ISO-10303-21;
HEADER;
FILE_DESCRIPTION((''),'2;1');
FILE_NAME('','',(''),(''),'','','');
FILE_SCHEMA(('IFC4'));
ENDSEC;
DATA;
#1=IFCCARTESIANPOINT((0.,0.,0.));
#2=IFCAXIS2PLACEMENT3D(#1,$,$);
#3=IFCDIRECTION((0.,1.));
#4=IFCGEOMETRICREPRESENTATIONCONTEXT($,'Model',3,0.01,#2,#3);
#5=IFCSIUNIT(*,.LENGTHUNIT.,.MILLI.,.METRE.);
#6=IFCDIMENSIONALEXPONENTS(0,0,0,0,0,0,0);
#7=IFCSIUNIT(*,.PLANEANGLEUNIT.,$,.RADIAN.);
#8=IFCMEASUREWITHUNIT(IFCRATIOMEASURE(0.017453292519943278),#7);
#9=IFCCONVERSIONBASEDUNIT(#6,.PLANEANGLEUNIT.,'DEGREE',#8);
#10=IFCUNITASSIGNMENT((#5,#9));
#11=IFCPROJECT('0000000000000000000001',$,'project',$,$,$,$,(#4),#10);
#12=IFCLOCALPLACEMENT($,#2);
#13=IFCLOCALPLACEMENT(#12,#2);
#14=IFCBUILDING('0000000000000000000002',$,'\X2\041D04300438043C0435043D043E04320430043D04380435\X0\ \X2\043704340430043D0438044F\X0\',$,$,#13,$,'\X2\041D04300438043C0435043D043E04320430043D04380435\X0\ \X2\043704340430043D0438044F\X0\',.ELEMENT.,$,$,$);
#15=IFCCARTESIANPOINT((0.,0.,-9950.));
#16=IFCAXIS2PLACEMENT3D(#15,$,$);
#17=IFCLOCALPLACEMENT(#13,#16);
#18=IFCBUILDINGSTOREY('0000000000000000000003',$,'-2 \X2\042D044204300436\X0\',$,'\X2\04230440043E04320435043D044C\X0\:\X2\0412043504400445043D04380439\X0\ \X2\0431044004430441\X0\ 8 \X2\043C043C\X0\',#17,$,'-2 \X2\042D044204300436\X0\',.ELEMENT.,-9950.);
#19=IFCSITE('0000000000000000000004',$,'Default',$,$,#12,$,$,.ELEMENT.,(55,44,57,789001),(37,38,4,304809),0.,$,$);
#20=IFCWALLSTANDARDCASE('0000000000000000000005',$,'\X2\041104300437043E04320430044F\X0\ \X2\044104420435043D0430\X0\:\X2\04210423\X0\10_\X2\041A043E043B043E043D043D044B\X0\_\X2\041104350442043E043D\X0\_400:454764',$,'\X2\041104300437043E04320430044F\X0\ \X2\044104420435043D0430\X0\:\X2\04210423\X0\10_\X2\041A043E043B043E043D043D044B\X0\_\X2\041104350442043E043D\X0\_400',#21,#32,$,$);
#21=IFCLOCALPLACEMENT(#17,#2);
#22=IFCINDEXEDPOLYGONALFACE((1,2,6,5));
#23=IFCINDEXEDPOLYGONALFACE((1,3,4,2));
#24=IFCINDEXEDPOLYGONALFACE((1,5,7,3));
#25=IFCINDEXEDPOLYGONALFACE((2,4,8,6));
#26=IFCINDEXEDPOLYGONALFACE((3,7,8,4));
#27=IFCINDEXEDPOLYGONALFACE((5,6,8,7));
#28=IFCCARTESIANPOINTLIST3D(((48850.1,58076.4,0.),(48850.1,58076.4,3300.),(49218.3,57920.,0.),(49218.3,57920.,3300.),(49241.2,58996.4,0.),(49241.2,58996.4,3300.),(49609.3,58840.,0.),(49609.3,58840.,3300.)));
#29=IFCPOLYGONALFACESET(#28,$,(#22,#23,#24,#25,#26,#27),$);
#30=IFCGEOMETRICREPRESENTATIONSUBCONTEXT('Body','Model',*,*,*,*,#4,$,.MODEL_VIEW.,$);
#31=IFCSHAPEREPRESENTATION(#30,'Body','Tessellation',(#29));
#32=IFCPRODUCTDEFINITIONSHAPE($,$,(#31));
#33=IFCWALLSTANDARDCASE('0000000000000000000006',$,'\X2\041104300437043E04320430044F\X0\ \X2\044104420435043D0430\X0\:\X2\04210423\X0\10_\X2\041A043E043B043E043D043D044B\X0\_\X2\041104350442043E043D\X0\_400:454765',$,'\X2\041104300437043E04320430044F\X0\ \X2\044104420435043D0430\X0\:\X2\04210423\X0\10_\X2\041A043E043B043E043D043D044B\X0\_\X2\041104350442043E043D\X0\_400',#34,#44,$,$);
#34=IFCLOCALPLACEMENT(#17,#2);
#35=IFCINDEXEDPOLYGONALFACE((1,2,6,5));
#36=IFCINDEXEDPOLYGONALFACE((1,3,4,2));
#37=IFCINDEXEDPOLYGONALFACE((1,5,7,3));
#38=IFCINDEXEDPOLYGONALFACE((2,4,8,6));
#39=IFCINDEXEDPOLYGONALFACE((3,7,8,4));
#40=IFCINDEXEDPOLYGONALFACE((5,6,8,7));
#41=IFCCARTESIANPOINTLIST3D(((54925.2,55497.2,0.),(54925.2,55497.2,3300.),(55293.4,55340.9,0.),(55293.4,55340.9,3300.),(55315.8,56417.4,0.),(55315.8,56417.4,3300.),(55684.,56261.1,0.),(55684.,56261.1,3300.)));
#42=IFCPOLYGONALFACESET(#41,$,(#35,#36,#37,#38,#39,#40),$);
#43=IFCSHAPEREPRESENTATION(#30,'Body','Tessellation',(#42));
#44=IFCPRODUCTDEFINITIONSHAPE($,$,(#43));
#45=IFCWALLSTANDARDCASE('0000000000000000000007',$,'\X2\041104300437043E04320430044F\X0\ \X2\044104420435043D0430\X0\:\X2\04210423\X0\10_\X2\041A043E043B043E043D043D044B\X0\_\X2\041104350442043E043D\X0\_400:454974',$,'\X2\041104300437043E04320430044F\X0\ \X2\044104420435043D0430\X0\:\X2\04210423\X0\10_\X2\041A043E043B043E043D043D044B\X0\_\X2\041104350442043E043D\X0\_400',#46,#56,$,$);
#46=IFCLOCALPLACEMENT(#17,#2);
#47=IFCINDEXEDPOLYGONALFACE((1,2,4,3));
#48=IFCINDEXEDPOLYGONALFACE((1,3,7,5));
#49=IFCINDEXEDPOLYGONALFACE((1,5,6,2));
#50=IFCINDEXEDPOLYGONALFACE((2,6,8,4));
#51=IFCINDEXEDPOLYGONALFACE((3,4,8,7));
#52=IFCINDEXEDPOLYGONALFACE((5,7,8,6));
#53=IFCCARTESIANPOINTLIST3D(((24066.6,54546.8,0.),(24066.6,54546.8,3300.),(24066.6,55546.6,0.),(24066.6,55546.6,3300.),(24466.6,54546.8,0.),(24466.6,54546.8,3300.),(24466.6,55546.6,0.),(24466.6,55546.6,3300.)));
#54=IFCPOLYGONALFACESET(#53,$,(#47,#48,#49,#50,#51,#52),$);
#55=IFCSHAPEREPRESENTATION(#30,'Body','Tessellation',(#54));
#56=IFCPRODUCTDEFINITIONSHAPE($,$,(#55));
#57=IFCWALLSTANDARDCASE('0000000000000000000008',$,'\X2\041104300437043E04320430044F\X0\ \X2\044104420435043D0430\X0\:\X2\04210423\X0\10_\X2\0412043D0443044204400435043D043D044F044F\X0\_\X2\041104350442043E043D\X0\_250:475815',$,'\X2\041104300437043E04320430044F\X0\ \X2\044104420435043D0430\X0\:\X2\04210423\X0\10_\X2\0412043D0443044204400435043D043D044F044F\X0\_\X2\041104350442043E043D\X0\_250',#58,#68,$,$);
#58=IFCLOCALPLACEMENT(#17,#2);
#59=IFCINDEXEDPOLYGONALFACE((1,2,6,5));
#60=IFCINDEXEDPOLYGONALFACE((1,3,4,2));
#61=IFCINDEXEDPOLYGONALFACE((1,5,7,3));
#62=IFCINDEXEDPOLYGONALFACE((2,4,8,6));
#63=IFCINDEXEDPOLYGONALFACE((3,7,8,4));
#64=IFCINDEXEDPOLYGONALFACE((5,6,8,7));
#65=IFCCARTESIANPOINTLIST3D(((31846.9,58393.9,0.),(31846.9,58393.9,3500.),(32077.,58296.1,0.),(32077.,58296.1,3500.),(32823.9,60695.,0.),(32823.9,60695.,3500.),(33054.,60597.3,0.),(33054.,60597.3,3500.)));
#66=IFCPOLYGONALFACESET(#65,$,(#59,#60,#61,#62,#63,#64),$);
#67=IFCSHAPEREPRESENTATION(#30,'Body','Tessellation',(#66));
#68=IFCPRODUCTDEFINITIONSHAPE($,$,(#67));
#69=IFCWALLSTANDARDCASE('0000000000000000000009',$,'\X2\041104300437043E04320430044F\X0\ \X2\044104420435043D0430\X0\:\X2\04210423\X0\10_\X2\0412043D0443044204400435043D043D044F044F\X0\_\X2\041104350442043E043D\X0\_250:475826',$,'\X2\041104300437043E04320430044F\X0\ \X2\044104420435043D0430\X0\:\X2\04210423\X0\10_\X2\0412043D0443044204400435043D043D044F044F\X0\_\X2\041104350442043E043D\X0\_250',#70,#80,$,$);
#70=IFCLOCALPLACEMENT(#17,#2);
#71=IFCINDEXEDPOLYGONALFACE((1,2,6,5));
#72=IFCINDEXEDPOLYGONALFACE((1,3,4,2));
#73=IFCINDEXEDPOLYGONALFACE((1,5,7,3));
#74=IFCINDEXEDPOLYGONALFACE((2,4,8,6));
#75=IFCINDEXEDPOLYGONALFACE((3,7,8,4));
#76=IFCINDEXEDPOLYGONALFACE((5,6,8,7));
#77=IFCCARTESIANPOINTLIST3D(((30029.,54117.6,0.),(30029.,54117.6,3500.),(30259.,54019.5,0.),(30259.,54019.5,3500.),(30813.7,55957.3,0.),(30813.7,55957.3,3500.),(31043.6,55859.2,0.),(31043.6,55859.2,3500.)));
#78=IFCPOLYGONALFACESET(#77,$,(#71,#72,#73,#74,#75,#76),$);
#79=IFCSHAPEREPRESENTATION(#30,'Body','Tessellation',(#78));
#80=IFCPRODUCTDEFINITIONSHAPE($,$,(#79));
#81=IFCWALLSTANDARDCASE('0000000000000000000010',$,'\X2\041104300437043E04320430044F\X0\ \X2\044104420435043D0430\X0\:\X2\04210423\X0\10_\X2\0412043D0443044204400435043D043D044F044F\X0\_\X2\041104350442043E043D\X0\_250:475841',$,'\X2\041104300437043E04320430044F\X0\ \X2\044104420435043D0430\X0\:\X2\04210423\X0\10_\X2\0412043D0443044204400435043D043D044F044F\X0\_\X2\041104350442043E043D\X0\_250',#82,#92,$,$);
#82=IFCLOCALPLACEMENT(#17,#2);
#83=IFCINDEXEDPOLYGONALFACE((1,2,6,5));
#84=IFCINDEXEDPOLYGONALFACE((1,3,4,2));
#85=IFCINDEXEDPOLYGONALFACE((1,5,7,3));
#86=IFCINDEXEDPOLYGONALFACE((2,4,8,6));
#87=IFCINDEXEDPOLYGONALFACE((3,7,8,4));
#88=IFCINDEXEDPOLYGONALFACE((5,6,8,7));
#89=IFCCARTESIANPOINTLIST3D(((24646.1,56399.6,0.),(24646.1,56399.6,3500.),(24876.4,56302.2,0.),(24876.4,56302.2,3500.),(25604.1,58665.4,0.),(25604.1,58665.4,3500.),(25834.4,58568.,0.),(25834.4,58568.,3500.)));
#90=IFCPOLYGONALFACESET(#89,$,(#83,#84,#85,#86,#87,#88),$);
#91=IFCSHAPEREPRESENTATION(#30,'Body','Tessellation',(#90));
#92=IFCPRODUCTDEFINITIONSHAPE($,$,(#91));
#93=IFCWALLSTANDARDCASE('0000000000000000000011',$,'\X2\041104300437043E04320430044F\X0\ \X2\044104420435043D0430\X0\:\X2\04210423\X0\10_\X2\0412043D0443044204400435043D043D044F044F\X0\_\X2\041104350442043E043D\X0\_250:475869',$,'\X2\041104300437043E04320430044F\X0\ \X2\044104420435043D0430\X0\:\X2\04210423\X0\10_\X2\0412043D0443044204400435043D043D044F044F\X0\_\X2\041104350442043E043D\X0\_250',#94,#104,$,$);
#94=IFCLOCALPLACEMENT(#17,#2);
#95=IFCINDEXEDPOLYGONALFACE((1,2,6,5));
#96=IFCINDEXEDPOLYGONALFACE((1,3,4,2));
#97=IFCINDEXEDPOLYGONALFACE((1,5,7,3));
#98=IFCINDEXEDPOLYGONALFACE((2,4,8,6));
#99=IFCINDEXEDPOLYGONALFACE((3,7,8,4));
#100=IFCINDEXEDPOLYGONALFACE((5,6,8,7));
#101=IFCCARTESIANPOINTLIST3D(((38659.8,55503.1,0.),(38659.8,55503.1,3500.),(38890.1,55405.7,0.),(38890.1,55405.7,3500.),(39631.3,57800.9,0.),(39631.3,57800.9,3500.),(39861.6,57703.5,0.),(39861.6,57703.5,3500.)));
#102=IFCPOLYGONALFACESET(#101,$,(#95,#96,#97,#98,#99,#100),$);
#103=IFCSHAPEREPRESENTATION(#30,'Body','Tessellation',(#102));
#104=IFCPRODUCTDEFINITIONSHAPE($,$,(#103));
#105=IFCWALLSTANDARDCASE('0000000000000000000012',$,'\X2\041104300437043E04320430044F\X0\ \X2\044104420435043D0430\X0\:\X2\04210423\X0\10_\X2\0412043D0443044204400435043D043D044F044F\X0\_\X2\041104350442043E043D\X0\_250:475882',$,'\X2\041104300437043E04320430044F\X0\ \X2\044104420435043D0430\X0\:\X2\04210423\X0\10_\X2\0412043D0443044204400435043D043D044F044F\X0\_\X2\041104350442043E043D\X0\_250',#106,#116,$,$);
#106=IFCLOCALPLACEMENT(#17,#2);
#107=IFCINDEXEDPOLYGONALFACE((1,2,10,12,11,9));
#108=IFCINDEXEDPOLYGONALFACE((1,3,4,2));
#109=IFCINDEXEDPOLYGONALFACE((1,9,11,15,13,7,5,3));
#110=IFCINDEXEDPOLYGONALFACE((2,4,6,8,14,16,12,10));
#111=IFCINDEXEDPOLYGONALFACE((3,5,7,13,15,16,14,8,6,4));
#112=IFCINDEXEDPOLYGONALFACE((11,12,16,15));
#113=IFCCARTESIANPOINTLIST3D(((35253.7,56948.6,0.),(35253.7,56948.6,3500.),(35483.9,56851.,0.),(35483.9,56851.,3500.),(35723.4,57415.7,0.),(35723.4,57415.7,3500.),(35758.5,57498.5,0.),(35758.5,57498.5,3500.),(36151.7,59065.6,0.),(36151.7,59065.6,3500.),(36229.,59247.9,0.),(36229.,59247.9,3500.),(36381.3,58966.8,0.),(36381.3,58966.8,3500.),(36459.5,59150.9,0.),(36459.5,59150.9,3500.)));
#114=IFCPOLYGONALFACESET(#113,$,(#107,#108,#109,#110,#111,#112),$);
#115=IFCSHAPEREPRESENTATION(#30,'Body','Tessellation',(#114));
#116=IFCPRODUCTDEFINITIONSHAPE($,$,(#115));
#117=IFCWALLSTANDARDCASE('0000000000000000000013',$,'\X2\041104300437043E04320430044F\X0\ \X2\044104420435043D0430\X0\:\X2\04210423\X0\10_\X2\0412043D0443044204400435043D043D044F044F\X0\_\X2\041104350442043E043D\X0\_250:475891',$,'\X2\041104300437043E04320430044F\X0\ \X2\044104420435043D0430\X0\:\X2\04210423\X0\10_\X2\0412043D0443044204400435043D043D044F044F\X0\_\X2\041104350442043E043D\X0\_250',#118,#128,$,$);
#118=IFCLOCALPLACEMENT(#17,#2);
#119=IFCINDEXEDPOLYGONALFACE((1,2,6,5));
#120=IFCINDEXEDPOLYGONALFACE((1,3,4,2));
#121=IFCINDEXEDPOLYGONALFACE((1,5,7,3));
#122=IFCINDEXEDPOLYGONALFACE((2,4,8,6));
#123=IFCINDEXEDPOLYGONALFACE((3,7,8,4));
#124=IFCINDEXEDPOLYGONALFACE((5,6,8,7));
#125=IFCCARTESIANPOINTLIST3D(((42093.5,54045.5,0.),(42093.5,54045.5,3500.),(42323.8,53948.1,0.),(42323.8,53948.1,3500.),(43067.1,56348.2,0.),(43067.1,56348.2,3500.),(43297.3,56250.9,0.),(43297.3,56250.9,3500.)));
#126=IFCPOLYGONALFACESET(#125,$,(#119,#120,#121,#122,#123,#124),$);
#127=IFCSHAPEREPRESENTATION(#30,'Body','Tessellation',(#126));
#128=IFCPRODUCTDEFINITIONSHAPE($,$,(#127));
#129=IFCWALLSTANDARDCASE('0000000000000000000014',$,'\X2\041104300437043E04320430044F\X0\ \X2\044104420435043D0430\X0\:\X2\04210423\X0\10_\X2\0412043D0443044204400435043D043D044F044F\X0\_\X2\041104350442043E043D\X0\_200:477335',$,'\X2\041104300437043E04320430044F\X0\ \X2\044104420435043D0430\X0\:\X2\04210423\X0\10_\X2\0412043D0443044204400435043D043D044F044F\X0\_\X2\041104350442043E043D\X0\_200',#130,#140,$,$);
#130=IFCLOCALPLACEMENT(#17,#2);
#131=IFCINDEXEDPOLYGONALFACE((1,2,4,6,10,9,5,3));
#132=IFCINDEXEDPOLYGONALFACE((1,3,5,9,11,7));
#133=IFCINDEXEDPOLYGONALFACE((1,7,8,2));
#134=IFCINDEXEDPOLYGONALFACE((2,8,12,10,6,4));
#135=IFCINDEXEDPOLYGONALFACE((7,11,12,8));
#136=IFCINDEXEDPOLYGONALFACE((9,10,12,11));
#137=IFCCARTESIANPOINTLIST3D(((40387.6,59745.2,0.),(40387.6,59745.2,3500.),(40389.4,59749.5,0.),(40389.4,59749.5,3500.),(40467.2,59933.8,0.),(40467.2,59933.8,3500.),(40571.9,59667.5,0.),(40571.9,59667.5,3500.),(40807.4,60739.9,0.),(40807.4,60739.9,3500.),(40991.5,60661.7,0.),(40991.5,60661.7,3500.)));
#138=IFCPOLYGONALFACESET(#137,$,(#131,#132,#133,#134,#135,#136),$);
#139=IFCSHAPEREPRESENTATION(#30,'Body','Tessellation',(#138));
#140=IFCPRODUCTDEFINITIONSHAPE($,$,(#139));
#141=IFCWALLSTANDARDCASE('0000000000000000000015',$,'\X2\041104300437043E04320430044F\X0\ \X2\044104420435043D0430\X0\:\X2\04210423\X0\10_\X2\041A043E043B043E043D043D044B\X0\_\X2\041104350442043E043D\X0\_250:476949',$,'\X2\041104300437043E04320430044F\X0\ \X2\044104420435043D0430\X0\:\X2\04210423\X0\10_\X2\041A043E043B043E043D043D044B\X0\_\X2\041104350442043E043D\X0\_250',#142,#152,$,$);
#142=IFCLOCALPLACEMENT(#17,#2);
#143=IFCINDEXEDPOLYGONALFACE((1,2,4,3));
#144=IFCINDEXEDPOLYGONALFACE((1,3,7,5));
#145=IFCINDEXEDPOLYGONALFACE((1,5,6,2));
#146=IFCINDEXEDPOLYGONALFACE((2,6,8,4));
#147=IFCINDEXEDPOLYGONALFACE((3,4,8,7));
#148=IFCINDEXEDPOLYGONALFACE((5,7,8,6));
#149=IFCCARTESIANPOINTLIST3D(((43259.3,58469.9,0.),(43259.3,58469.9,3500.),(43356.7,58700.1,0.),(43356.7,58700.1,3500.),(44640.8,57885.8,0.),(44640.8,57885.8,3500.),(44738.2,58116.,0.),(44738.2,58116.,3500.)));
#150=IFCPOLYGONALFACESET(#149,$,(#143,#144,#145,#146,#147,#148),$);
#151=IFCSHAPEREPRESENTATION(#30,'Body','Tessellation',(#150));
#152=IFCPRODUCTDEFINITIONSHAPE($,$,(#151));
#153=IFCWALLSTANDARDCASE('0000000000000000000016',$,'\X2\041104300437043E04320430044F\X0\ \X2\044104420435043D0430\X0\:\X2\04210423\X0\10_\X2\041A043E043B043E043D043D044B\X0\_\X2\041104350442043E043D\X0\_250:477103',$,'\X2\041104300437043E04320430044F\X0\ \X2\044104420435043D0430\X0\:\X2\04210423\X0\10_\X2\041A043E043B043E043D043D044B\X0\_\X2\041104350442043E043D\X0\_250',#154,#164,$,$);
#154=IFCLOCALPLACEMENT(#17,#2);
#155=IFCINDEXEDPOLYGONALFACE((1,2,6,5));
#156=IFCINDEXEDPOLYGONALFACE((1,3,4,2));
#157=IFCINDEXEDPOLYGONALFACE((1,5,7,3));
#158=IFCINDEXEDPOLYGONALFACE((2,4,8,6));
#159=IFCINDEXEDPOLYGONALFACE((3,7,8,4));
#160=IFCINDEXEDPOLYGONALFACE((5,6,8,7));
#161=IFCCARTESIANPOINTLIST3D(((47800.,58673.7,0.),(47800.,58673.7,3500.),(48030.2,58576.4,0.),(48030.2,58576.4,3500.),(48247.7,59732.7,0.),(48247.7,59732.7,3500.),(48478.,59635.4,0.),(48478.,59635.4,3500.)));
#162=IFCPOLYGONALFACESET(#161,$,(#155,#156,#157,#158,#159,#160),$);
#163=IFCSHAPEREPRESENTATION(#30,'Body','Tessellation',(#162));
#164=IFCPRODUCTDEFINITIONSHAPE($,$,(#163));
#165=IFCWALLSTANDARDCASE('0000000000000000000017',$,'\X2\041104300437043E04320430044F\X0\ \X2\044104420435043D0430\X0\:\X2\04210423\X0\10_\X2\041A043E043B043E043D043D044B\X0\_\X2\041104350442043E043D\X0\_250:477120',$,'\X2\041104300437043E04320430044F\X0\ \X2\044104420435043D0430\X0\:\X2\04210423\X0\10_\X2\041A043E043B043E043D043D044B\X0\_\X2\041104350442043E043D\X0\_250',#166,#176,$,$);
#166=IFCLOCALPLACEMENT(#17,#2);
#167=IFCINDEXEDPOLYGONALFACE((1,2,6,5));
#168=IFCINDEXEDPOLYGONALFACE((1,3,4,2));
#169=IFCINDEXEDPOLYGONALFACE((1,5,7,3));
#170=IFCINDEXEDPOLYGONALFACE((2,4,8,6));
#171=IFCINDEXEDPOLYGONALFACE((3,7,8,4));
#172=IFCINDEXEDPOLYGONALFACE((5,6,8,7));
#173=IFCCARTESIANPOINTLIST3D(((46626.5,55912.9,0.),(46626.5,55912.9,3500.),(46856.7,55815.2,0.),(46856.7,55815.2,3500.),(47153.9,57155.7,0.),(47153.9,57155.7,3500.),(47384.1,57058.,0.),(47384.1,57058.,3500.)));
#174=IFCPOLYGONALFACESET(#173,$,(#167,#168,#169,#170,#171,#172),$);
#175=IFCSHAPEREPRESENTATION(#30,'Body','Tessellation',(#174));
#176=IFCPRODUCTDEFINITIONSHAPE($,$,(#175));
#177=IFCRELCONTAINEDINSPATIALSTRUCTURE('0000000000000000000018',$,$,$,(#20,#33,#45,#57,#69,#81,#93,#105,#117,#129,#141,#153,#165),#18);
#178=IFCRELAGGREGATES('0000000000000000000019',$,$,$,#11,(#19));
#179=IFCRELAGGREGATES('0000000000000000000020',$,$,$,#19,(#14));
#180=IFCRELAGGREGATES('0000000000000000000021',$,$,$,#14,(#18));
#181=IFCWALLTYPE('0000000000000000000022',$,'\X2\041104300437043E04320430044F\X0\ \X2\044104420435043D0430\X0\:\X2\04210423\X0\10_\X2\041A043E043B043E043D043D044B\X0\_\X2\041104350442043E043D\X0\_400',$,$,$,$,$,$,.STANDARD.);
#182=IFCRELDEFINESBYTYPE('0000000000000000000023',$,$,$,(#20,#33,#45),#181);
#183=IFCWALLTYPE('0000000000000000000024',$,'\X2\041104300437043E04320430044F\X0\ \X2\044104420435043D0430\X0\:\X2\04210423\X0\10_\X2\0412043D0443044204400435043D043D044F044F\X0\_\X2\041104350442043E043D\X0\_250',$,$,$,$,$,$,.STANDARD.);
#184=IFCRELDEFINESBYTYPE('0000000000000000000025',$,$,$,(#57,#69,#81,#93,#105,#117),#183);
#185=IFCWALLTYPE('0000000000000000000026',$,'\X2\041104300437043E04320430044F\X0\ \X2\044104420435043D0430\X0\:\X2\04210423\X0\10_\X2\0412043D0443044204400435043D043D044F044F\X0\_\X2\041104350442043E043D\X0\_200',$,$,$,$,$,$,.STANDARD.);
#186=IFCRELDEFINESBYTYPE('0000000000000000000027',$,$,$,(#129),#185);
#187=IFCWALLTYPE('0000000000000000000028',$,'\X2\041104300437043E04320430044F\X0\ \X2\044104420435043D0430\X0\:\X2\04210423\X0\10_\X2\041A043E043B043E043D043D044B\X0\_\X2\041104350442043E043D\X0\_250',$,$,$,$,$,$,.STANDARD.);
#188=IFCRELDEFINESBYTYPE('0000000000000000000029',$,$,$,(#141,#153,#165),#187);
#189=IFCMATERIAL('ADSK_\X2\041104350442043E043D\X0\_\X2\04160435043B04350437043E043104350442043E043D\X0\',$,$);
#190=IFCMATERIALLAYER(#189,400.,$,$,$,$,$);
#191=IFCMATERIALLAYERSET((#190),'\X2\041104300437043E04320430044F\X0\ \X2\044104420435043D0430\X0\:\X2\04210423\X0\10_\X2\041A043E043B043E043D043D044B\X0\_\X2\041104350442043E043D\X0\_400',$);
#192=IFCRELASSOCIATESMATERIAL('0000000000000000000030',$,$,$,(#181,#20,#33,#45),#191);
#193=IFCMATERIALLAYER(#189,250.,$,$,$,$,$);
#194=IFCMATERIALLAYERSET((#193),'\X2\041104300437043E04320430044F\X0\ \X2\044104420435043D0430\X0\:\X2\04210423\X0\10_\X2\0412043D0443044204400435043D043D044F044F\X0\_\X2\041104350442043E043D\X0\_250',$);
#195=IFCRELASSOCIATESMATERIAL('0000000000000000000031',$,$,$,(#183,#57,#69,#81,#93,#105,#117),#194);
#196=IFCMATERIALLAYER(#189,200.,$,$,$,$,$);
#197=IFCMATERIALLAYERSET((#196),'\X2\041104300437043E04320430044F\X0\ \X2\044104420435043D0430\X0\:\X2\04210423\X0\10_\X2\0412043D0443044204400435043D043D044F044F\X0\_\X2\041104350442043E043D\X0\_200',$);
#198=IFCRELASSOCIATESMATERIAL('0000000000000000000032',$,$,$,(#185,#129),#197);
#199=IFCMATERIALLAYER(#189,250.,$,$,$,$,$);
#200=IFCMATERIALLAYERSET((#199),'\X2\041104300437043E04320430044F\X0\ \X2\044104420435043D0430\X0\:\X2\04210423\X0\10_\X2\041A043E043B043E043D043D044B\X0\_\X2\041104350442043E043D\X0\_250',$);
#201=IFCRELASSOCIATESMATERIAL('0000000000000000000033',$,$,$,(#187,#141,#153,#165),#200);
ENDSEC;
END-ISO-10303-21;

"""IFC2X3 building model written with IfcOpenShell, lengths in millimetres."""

from ifc_helpers import new_model, entity, si_unit, converted_unit, direction, frame, frame_2d, origin, place, context, subcontext, project, spatial, polyline, rectangle, outline, extrude, material, layer, layer_set, layer_usage, type_object, element, save


model = new_model("IFC2X3")

# Units and contexts
model_context = context("Model", 3, precision=0.01, world=origin(), true_north=direction((0.0, 1.0)))
body_context = subcontext(model_context, "Body", "Model", "MODEL_VIEW")
ifc_project = project(units=[si_unit("LENGTHUNIT", "METRE", prefix="MILLI"), converted_unit("PLANEANGLEUNIT", "DEGREE", entity("IfcRatioMeasure", 0.017453292519943278), si_unit("PLANEANGLEUNIT", "RADIAN"), dimensions=[0, 0, 0, 0, 0, 0, 0])], contexts=[model_context])

# Site, building, storey
site_placement = place(None, origin())
site = spatial("IfcSite", under=ifc_project, at=site_placement, Name="Default", CompositionType="ELEMENT", RefLatitude=(55, 44, 57, 789001), RefLongitude=(37, 38, 4, 304809), RefElevation=0.0)
building_placement = place(site_placement, origin())
building = spatial("IfcBuilding", under=site, at=building_placement, Name="Наименование здания", LongName="Наименование здания", CompositionType="ELEMENT")
storey_placement = place(building_placement, frame((0.0, 0.0, -9950.0)))
storey = spatial("IfcBuildingStorey", under=building, at=storey_placement, Name="-2 Этаж", ObjectType="Уровень:Верхний брус 8 мм", LongName="-2 Этаж", CompositionType="ELEMENT", Elevation=-9950.0)

# Walls
ifc_material_1 = material(Name="ADSK_Бетон_Железобетон")
ifc_layer_1 = layer(ifc_material_1, 400.0)
ifc_layer_set_1 = layer_set([ifc_layer_1], Name="Базовая стена:СУ10_Колонны_Бетон_400")
ifc_layer_usage_1 = layer_usage(ifc_layer_set_1, "AXIS2", "NEGATIVE", 200.0)
wall_type_1 = type_object("IfcWallType", Name="Базовая стена:СУ10_Колонны_Бетон_400", PredefinedType="STANDARD", material=ifc_layer_set_1)
wall_1_placement = place(storey_placement, frame((49034.2, 57998.2, 0.0), z_axis=(0.0, 0.0, 1.0), x_axis=(0.391159, 0.920323, 0.0)))
element("IfcWallStandardCase", 1, at=wall_1_placement, inside=storey, type_object=wall_type_1, material=ifc_layer_usage_1, Name="Базовая стена:СУ10_Колонны_Бетон_400:454764", ObjectType="Базовая стена:СУ10_Колонны_Бетон_400", context=body_context, shape_type="SweptSolid", body=[
    extrude(rectangle(XDim=999.7, YDim=400.0, at=frame_2d((499.8, 0.0), x_axis=(-1.0, 0.0))), origin(), (0.0, 0.0, 1.0), 3300.0),
])
wall_2_placement = place(storey_placement, frame((55109.3, 55419.1, 0.0), z_axis=(0.0, 0.0, 1.0), x_axis=(0.390736, 0.920503, 0.0)))
element("IfcWallStandardCase", 2, at=wall_2_placement, inside=storey, type_object=wall_type_1, material=ifc_layer_usage_1, Name="Базовая стена:СУ10_Колонны_Бетон_400:454765", ObjectType="Базовая стена:СУ10_Колонны_Бетон_400", context=body_context, shape_type="SweptSolid", body=[
    extrude(rectangle(XDim=999.7, YDim=400.0, at=frame_2d((499.8, 0.0), x_axis=(-1.0, 0.0))), origin(), (0.0, 0.0, 1.0), 3300.0),
])
wall_3_placement = place(storey_placement, frame((24266.6, 55546.6, 0.0), z_axis=(0.0, 0.0, 1.0), x_axis=(0.0, -1.0, 0.0)))
element("IfcWallStandardCase", 3, at=wall_3_placement, inside=storey, type_object=wall_type_1, material=ifc_layer_usage_1, Name="Базовая стена:СУ10_Колонны_Бетон_400:454974", ObjectType="Базовая стена:СУ10_Колонны_Бетон_400", context=body_context, shape_type="SweptSolid", body=[
    extrude(rectangle(XDim=999.8, YDim=400.0, at=frame_2d((499.9, 0.0), x_axis=(-1.0, 0.0))), origin(), (0.0, 0.0, 1.0), 3300.0),
])
ifc_layer_2 = layer(ifc_material_1, 250.0)
ifc_layer_set_2 = layer_set([ifc_layer_2], Name="Базовая стена:СУ10_Внутренняя_Бетон_250")
ifc_layer_usage_2 = layer_usage(ifc_layer_set_2, "AXIS2", "NEGATIVE", 125.0)
wall_type_2 = type_object("IfcWallType", Name="Базовая стена:СУ10_Внутренняя_Бетон_250", PredefinedType="STANDARD", material=ifc_layer_set_2)
wall_4_placement = place(storey_placement, frame((31961.9, 58345.0, 0.0), z_axis=(0.0, 0.0, 1.0), x_axis=(0.390813, 0.92047, 0.0)))
element("IfcWallStandardCase", 4, at=wall_4_placement, inside=storey, type_object=wall_type_2, material=ifc_layer_usage_2, Name="Базовая стена:СУ10_Внутренняя_Бетон_250:475815", ObjectType="Базовая стена:СУ10_Внутренняя_Бетон_250", context=body_context, shape_type="SweptSolid", body=[
    extrude(rectangle(XDim=2500.0, YDim=250.0, at=frame_2d((1250.0, 0.0), x_axis=(-1.0, 0.0))), origin(), (0.0, 0.0, 1.0), 3500.0),
])
wall_5_placement = place(storey_placement, frame((30144.0, 54068.6, 0.0), z_axis=(0.0, 0.0, 1.0), x_axis=(0.392312, 0.919832, 0.0)))
element("IfcWallStandardCase", 5, at=wall_5_placement, inside=storey, type_object=wall_type_2, material=ifc_layer_usage_2, Name="Базовая стена:СУ10_Внутренняя_Бетон_250:475826", ObjectType="Базовая стена:СУ10_Внутренняя_Бетон_250", context=body_context, shape_type="SweptSolid", body=[
    extrude(rectangle(XDim=2000.0, YDim=250.0, at=frame_2d((1000.0, 0.0), x_axis=(-1.0, 0.0))), origin(), (0.0, 0.0, 1.0), 3500.0),
])
wall_6_placement = place(storey_placement, frame((24761.3, 56350.9, 0.0), z_axis=(0.0, 0.0, 1.0), x_axis=(0.389429, 0.921057, 0.0)))
element("IfcWallStandardCase", 6, at=wall_6_placement, inside=storey, type_object=wall_type_2, material=ifc_layer_usage_2, Name="Базовая стена:СУ10_Внутренняя_Бетон_250:475841", ObjectType="Базовая стена:СУ10_Внутренняя_Бетон_250", context=body_context, shape_type="SweptSolid", body=[
    extrude(rectangle(XDim=2460.0, YDim=250.0, at=frame_2d((1230.0, 0.0), x_axis=(-1.0, 0.0))), origin(), (0.0, 0.0, 1.0), 3500.0),
])
wall_7_placement = place(storey_placement, frame((38774.9, 55454.4, 0.0), z_axis=(0.0, 0.0, 1.0), x_axis=(0.389417, 0.921062, 0.0)))
element("IfcWallStandardCase", 7, at=wall_7_placement, inside=storey, type_object=wall_type_2, material=ifc_layer_usage_2, Name="Базовая стена:СУ10_Внутренняя_Бетон_250:475869", ObjectType="Базовая стена:СУ10_Внутренняя_Бетон_250", context=body_context, shape_type="SweptSolid", body=[
    extrude(rectangle(XDim=2494.7, YDim=250.0, at=frame_2d((1247.4, 0.0), x_axis=(-1.0, 0.0))), origin(), (0.0, 0.0, 1.0), 3500.0),
])
wall_8_placement = place(storey_placement, frame((35368.8, 56899.8, 0.0), z_axis=(0.0, 0.0, 1.0), x_axis=(0.390507, 0.9206, 0.0)))
element("IfcWallStandardCase", 8, at=wall_8_placement, inside=storey, type_object=wall_type_2, material=ifc_layer_usage_2, Name="Базовая стена:СУ10_Внутренняя_Бетон_250:475882", ObjectType="Базовая стена:СУ10_Внутренняя_Бетон_250", context=body_context, shape_type="SweptSolid", body=[
    extrude(outline(polyline([(2498.3, -125.0), (2497.6, 125.0), (2299.5, 125.0), (0.0, 125.0), (0.0, -125.0), (613.4, -125.0), (703.4, -125.0), (2298.2, -125.0), (2498.3, -125.0)])), origin(), (0.0, 0.0, 1.0), 3500.0),
])
wall_9_placement = place(storey_placement, frame((42208.6, 53996.8, 0.0), z_axis=(0.0, 0.0, 1.0), x_axis=(0.389417, 0.921062, 0.0)))
element("IfcWallStandardCase", 9, at=wall_9_placement, inside=storey, type_object=wall_type_2, material=ifc_layer_usage_2, Name="Базовая стена:СУ10_Внутренняя_Бетон_250:475891", ObjectType="Базовая стена:СУ10_Внутренняя_Бетон_250", context=body_context, shape_type="SweptSolid", body=[
    extrude(rectangle(XDim=2500.1, YDim=250.0, at=frame_2d((1250.1, 0.0), x_axis=(-1.0, 0.0))), origin(), (0.0, 0.0, 1.0), 3500.0),
])
ifc_layer_3 = layer(ifc_material_1, 200.0)
ifc_layer_set_3 = layer_set([ifc_layer_3], Name="Базовая стена:СУ10_Внутренняя_Бетон_200")
ifc_layer_usage_3 = layer_usage(ifc_layer_set_3, "AXIS2", "NEGATIVE", 100.0)
wall_type_3 = type_object("IfcWallType", Name="Базовая стена:СУ10_Внутренняя_Бетон_200", PredefinedType="STANDARD", material=ifc_layer_set_3)
wall_10_placement = place(storey_placement, frame((40479.7, 59706.3, 0.0), z_axis=(0.0, 0.0, 1.0), x_axis=(0.388823, 0.921313, 0.0)))
element("IfcWallStandardCase", 10, at=wall_10_placement, inside=storey, type_object=wall_type_3, material=ifc_layer_usage_3, Name="Базовая стена:СУ10_Внутренняя_Бетон_200:477335", ObjectType="Базовая стена:СУ10_Внутренняя_Бетон_200", context=body_context, shape_type="SweptSolid", body=[
    extrude(outline(polyline([(1079.1, -100.0), (1079.7, 100.0), (204.6, 100.0), (4.6, 100.0), (0.0, 100.0), (0.0, -100.0), (1079.1, -100.0)])), origin(), (0.0, 0.0, 1.0), 3500.0),
])
ifc_layer_4 = layer(ifc_material_1, 250.0)
ifc_layer_set_4 = layer_set([ifc_layer_4], Name="Базовая стена:СУ10_Колонны_Бетон_250")
ifc_layer_usage_4 = layer_usage(ifc_layer_set_4, "AXIS2", "NEGATIVE", 125.0)
wall_type_4 = type_object("IfcWallType", Name="Базовая стена:СУ10_Колонны_Бетон_250", PredefinedType="STANDARD", material=ifc_layer_set_4)
wall_11_placement = place(storey_placement, frame((44689.5, 58000.9, 0.0), z_axis=(0.0, 0.0, 1.0), x_axis=(-0.921062, 0.389417, 0.0)))
element("IfcWallStandardCase", 11, at=wall_11_placement, inside=storey, type_object=wall_type_4, material=ifc_layer_usage_4, Name="Базовая стена:СУ10_Колонны_Бетон_250:476949", ObjectType="Базовая стена:СУ10_Колонны_Бетон_250", context=body_context, shape_type="SweptSolid", body=[
    extrude(rectangle(XDim=1499.9, YDim=250.0, at=frame_2d((750.0, 0.0), x_axis=(-1.0, 0.0))), origin(), (0.0, 0.0, 1.0), 3500.0),
])
wall_12_placement = place(storey_placement, frame((47915.1, 58625.1, 0.0), z_axis=(0.0, 0.0, 1.0), x_axis=(0.389429, 0.921057, 0.0)))
element("IfcWallStandardCase", 12, at=wall_12_placement, inside=storey, type_object=wall_type_4, material=ifc_layer_usage_4, Name="Базовая стена:СУ10_Колонны_Бетон_250:477103", ObjectType="Базовая стена:СУ10_Колонны_Бетон_250", context=body_context, shape_type="SweptSolid", body=[
    extrude(rectangle(XDim=1149.8, YDim=250.0, at=frame_2d((574.9, 0.0), x_axis=(-1.0, 0.0))), origin(), (0.0, 0.0, 1.0), 3500.0),
])
wall_13_placement = place(storey_placement, frame((46741.6, 55864.1, 0.0), z_axis=(0.0, 0.0, 1.0), x_axis=(0.390642, 0.920543, 0.0)))
element("IfcWallStandardCase", 13, at=wall_13_placement, inside=storey, type_object=wall_type_4, material=ifc_layer_usage_4, Name="Базовая стена:СУ10_Колонны_Бетон_250:477120", ObjectType="Базовая стена:СУ10_Колонны_Бетон_250", context=body_context, shape_type="SweptSolid", body=[
    extrude(rectangle(XDim=1350.1, YDim=250.0, at=frame_2d((675.0, 0.0), x_axis=(-1.0, 0.0))), origin(), (0.0, 0.0, 1.0), 3500.0),
])

save(model, "model.ifc")
